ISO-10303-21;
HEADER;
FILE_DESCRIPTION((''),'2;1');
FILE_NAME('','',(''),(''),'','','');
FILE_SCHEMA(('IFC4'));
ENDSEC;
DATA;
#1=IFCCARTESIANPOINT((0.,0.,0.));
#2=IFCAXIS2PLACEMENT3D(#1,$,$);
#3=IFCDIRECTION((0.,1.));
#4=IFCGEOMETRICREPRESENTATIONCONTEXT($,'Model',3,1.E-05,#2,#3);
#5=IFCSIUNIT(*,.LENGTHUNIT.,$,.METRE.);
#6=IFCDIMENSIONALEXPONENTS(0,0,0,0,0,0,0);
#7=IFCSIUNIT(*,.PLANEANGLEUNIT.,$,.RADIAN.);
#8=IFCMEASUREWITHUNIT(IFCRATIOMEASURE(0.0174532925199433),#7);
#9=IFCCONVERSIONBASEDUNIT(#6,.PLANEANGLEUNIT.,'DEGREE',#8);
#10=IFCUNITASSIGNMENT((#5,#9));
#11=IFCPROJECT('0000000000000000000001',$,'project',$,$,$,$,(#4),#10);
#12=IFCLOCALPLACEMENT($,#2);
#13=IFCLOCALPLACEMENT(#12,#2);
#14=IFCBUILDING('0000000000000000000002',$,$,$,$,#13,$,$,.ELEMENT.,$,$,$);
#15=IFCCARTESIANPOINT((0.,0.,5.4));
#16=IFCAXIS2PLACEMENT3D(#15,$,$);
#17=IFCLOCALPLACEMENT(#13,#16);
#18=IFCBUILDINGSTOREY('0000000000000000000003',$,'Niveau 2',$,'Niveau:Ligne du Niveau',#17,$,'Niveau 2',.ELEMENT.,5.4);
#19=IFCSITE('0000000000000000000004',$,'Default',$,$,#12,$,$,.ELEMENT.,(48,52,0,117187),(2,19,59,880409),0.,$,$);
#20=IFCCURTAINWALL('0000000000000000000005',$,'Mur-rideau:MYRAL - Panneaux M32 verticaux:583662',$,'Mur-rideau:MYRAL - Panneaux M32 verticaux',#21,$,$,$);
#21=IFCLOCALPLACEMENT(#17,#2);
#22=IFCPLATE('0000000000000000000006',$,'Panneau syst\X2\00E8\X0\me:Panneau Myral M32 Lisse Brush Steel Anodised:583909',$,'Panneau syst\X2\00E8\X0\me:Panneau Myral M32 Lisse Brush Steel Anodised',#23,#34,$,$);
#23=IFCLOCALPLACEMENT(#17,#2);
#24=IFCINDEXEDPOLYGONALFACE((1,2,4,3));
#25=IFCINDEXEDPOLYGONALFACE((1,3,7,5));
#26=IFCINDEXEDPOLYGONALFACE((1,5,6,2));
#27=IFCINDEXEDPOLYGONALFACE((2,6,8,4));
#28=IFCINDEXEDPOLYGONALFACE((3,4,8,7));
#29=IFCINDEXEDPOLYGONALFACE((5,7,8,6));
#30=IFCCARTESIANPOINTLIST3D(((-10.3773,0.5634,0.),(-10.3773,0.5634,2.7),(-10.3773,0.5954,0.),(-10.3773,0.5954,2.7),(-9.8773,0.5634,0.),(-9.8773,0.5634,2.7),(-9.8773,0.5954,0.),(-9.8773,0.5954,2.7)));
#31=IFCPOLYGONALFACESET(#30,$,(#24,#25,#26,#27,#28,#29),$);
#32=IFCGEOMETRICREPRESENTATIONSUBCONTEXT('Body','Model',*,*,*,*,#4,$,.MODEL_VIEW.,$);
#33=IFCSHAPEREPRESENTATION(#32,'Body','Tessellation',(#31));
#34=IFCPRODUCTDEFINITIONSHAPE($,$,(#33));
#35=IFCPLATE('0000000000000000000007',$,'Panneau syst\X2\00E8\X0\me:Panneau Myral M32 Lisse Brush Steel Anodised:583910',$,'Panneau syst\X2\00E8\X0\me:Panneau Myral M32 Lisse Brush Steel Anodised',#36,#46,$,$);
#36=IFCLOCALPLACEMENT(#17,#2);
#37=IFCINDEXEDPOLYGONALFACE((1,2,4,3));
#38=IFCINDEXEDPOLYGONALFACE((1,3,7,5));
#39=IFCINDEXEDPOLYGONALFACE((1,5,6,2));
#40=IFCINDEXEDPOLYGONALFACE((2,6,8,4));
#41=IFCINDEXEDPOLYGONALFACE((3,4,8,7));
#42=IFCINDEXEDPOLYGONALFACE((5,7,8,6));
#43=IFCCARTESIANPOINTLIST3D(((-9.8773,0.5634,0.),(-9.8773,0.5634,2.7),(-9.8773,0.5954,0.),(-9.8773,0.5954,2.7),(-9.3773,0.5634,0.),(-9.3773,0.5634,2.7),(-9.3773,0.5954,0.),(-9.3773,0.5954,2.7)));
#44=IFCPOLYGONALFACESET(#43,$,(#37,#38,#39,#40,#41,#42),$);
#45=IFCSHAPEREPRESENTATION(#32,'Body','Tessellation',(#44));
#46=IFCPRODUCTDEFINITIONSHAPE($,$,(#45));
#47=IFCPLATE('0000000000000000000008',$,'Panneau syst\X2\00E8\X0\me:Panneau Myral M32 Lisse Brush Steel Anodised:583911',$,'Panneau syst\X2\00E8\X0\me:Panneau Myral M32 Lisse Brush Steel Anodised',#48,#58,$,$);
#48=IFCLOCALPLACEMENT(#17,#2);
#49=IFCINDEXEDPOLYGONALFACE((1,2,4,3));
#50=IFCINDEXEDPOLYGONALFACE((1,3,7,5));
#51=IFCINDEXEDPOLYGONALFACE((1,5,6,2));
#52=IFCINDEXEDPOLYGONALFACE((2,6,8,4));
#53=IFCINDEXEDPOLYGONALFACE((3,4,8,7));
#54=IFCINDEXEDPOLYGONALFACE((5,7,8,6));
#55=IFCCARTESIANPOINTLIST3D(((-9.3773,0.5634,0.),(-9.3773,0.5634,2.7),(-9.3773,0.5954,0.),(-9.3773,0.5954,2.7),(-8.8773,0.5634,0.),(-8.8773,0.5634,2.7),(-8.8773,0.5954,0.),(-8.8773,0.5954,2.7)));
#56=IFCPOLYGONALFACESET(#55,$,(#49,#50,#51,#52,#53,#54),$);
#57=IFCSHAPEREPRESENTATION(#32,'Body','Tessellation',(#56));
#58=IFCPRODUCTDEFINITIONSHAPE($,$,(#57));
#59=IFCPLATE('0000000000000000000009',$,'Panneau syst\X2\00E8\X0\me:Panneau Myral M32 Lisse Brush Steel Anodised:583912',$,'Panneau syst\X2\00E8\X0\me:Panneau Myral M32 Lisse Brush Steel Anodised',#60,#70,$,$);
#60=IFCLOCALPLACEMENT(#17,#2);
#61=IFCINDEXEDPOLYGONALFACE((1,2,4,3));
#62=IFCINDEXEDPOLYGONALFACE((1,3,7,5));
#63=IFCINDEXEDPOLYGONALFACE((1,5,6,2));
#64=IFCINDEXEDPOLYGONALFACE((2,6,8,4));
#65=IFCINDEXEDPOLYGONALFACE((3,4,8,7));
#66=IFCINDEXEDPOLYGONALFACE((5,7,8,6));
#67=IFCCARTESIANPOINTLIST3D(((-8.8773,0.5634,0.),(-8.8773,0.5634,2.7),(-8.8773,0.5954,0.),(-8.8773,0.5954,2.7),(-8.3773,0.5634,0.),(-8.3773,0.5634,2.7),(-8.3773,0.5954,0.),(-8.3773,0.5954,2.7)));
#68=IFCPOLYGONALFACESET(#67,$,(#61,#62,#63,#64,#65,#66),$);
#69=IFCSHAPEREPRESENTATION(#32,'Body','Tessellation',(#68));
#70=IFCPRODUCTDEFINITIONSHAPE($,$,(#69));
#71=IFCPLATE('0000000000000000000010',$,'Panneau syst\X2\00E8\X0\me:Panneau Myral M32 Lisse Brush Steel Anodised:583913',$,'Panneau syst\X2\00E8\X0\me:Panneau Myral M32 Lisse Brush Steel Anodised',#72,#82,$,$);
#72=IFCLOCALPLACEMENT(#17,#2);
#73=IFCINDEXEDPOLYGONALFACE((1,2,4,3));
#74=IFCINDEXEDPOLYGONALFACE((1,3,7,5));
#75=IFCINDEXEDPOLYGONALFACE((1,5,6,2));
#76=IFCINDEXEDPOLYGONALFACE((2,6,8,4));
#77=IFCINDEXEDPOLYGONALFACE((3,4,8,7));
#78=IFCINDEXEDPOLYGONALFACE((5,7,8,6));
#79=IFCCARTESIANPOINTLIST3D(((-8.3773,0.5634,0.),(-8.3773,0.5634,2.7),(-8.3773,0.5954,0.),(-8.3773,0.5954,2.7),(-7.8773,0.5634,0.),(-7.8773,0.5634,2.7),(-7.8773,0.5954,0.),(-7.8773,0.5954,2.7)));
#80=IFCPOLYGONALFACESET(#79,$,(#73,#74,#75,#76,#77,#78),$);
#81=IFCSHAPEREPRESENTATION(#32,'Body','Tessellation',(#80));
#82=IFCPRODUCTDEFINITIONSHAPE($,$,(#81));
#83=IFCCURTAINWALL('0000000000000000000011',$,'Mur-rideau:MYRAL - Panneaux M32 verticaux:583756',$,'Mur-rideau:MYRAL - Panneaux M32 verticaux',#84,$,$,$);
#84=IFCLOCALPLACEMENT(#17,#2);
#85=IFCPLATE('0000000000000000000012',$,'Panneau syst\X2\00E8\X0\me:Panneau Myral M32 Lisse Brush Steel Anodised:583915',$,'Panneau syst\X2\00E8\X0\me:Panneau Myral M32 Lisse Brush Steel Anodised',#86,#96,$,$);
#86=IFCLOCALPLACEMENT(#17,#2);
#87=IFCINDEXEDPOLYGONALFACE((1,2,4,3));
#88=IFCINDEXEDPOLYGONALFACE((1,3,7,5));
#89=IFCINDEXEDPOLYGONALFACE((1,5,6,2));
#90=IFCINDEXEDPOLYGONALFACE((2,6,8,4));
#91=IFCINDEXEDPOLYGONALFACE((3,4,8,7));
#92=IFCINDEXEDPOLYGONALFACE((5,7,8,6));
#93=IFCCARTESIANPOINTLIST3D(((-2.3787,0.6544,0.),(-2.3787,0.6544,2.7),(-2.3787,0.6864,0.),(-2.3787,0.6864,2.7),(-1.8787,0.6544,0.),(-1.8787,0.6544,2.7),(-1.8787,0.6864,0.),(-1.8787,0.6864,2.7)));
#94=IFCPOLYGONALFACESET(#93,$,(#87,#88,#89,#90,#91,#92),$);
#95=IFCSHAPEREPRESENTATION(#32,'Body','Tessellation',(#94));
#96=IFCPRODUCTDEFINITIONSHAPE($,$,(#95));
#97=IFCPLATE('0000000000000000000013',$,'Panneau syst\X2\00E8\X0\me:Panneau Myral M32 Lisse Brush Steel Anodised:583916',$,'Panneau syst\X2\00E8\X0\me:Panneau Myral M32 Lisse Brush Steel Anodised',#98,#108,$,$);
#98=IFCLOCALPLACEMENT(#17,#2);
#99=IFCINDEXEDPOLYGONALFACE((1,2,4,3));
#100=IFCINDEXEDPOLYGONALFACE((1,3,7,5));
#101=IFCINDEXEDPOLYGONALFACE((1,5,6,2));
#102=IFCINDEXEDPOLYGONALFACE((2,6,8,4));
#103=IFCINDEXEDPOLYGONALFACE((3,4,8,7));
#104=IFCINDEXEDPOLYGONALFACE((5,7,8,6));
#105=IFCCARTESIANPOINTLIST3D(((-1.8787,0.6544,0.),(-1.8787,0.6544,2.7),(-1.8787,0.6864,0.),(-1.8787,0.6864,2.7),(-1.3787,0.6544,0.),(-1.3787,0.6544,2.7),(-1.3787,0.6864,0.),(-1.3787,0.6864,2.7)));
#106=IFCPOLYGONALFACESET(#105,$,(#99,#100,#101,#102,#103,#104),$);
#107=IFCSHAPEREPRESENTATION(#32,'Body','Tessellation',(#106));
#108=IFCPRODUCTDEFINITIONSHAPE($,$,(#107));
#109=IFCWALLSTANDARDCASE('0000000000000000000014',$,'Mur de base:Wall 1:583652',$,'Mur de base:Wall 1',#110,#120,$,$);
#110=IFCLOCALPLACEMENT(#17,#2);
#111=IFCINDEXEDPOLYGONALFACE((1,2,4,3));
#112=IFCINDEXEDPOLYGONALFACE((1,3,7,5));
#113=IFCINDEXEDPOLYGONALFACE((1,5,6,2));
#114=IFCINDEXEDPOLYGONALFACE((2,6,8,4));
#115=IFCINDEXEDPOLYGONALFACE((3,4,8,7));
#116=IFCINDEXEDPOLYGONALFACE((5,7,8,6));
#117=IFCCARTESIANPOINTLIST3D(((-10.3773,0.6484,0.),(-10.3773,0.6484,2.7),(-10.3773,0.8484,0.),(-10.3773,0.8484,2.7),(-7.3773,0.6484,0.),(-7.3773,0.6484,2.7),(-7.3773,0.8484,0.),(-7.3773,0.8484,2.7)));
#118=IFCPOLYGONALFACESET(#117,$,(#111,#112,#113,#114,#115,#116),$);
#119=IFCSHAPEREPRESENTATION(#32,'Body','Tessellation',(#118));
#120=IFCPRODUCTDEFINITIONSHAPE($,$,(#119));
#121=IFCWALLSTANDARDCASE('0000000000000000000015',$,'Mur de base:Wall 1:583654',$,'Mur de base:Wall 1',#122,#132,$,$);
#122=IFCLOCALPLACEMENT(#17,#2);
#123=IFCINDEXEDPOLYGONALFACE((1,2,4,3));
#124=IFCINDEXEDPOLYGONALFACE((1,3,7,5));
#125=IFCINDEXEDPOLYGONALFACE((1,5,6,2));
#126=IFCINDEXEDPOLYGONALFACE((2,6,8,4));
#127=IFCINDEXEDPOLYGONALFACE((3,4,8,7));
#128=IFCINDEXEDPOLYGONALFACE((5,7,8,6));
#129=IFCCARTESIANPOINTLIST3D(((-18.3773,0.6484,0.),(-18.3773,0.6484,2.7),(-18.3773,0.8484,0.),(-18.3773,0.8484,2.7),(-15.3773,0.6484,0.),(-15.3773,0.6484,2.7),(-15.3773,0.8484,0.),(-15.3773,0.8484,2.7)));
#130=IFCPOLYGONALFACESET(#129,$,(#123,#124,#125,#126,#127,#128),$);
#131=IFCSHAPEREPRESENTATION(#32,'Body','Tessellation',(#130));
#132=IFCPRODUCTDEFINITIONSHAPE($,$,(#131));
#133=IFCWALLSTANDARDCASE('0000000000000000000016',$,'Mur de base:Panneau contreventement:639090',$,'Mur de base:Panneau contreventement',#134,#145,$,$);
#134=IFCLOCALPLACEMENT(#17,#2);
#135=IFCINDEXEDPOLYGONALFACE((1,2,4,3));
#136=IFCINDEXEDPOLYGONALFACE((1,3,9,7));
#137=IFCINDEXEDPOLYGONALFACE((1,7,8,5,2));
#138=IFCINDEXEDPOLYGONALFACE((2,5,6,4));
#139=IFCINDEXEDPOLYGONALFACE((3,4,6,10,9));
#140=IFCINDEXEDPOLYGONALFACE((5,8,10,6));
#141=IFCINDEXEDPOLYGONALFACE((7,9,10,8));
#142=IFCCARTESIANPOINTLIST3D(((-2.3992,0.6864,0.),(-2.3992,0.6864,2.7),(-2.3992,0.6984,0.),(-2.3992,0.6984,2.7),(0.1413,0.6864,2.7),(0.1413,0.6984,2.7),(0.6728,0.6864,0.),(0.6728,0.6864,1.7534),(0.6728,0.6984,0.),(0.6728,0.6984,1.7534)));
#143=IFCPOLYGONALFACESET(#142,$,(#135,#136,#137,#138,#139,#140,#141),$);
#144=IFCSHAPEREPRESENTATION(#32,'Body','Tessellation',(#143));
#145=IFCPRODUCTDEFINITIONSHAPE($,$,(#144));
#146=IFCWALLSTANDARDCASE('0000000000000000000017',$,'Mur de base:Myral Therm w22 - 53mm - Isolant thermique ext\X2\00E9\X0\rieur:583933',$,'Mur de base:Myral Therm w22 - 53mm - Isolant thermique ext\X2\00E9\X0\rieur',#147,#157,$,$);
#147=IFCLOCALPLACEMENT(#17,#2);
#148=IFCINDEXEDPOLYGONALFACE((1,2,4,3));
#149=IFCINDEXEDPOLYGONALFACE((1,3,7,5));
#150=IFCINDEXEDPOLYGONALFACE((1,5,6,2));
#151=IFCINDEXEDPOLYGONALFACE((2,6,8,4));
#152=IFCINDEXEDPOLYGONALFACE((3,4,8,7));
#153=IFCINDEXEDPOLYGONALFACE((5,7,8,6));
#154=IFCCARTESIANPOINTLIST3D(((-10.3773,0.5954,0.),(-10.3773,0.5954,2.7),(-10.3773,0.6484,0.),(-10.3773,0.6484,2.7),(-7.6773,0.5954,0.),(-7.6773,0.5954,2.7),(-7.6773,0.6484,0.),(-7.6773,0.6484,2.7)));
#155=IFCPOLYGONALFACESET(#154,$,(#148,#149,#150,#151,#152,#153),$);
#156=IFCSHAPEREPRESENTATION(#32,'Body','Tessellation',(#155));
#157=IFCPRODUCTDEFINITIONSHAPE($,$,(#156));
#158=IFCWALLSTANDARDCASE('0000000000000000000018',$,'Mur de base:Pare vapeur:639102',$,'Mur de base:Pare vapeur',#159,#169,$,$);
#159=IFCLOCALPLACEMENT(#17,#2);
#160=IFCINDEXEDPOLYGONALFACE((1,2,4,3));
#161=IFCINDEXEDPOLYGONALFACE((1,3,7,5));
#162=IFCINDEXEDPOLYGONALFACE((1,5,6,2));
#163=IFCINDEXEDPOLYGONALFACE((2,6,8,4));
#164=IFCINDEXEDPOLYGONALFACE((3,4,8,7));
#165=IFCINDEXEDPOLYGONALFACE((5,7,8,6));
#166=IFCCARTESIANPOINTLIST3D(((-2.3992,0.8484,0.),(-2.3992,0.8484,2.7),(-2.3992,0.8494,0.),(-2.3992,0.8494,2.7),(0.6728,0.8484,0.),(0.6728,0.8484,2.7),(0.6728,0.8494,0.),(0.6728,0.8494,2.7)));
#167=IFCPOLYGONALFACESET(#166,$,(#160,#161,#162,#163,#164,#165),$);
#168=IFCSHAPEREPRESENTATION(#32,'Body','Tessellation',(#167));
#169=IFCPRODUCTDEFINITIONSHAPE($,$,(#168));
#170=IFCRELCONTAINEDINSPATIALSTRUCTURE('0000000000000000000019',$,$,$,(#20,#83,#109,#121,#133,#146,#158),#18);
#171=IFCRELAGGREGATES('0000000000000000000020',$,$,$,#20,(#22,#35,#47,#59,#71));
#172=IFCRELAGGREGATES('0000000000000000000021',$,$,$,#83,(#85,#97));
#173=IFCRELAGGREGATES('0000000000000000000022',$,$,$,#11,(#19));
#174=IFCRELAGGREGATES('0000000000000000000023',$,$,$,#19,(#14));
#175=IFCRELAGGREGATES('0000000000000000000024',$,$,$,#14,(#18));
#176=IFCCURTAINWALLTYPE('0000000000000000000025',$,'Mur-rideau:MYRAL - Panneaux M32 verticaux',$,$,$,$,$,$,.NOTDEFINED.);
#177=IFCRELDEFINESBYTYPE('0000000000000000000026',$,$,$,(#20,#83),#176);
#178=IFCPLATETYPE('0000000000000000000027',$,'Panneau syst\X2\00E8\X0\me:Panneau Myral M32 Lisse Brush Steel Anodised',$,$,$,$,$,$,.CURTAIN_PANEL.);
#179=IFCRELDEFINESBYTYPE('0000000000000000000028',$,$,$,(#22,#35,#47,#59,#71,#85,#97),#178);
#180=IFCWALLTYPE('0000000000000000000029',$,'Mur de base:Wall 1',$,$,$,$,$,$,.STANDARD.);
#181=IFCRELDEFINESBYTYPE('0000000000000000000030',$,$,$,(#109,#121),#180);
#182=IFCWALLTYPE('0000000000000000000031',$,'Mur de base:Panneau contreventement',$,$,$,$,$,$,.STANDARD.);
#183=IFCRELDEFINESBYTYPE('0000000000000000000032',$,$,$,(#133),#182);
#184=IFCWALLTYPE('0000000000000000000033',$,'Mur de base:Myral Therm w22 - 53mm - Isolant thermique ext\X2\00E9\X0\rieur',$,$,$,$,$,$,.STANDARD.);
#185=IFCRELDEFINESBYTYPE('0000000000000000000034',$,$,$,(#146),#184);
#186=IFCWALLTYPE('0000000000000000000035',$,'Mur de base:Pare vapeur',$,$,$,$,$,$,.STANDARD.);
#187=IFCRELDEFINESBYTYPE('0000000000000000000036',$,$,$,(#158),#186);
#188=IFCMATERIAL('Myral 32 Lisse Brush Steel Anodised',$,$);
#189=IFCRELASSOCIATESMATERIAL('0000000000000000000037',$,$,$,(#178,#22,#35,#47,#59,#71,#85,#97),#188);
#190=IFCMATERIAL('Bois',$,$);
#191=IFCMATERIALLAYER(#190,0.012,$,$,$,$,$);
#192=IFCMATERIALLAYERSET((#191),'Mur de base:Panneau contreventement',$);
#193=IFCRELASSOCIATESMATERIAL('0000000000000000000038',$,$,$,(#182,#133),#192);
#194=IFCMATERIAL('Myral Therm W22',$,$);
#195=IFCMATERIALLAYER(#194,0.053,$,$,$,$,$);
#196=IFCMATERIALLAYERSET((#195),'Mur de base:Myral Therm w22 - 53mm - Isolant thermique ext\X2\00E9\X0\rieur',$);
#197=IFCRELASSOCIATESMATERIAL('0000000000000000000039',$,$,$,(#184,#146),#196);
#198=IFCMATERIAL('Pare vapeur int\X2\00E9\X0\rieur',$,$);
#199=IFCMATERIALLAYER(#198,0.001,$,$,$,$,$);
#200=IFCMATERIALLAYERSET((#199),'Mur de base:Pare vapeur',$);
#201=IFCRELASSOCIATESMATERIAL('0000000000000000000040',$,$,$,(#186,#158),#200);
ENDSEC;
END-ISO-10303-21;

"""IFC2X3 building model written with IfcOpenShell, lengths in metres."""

from ifc_helpers import new_model, entity, si_unit, converted_unit, direction, frame, frame_2d, origin, origin_2d_with_axis, place, context, subcontext, project, spatial, rectangle, extrude, clip, halfspace, source, transform, mapped, material, layer, layer_set, layer_usage, type_object, type_shapes, element, aggregate, save


model = new_model("IFC2X3")

# Units and contexts
model_context = context("Model", 3, precision=1e-05, world=origin(), true_north=direction((0.0, 1.0)))
body_context = subcontext(model_context, "Body", "Model", "MODEL_VIEW")
ifc_project = project(units=[si_unit("LENGTHUNIT", "METRE"), converted_unit("PLANEANGLEUNIT", "DEGREE", entity("IfcRatioMeasure", 0.0174532925199433), si_unit("PLANEANGLEUNIT", "RADIAN"), dimensions=[0, 0, 0, 0, 0, 0, 0])], contexts=[model_context])

# Site, building, storey
site_placement = place(None, origin())
site = spatial("IfcSite", under=ifc_project, at=site_placement, Name="Default", CompositionType="ELEMENT", RefLatitude=(48, 52, 0, 117187), RefLongitude=(2, 19, 59, 880409), RefElevation=0.0)
building_placement = place(site_placement, origin())
building = spatial("IfcBuilding", under=site, at=building_placement, CompositionType="ELEMENT")
storey_placement = place(building_placement, frame((0.0, 0.0, 5.4)))
storey = spatial("IfcBuildingStorey", under=building, at=storey_placement, Name="Niveau 2", ObjectType="Niveau:Ligne du Niveau", LongName="Niveau 2", CompositionType="ELEMENT", Elevation=5.4)

# Shared definitions
ifc_material_1 = material(Name="Bois")

# Curtain walls, plates
curtain_wall_type_1 = type_object("IfcCurtainWallType", Name="Mur-rideau:MYRAL - Panneaux M32 verticaux", PredefinedType="NOTDEFINED")
ifc_material_2 = material(Name="Myral 32 Lisse Brush Steel Anodised")
plate_type = type_object("IfcPlateType", Name="Panneau système:Panneau Myral M32 Lisse Brush Steel Anodised", PredefinedType="CURTAIN_PANEL", material=ifc_material_2)
shared_shape_1 = source(origin(), body_context, "Body", "SweptSolid", [
    extrude(rectangle(XDim=0.032, YDim=0.5, at=origin_2d_with_axis()), frame((0.0, -0.016, 0.0), z_axis=(0.0, 0.0, 1.0), x_axis=(0.0, 1.0, 0.0)), (0.0, 0.0, 1.0), 2.7),
])
type_shapes(plate_type, [shared_shape_1])
curtain_wall_1_placement = place(storey_placement, frame((0.0, 0.0, -5.4)))
curtain_wall_1 = element("IfcCurtainWall", 1, at=curtain_wall_1_placement, inside=storey, type_object=curtain_wall_type_1, Name="Mur-rideau:MYRAL - Panneaux M32 verticaux:583662", ObjectType="Mur-rideau:MYRAL - Panneaux M32 verticaux")
plate_1_placement = place(curtain_wall_1_placement, frame((-10.1273, 0.5954, 5.4)))
plate_1 = element("IfcPlate", 2, at=plate_1_placement, type_object=plate_type, material=ifc_material_2, Name="Panneau système:Panneau Myral M32 Lisse Brush Steel Anodised:583909", ObjectType="Panneau système:Panneau Myral M32 Lisse Brush Steel Anodised", context=body_context, shape_type="MappedRepresentation", body=[
    mapped(shared_shape_1, transform((0.0, 0.0, 0.0), scale=1.0)),
])
plate_2_placement = place(curtain_wall_1_placement, frame((-9.6273, 0.5954, 5.4)))
plate_2 = element("IfcPlate", 3, at=plate_2_placement, type_object=plate_type, material=ifc_material_2, Name="Panneau système:Panneau Myral M32 Lisse Brush Steel Anodised:583910", ObjectType="Panneau système:Panneau Myral M32 Lisse Brush Steel Anodised", context=body_context, shape_type="MappedRepresentation", body=[
    mapped(shared_shape_1, transform((0.0, 0.0, 0.0), scale=1.0)),
])
plate_3_placement = place(curtain_wall_1_placement, frame((-9.1273, 0.5954, 5.4)))
plate_3 = element("IfcPlate", 4, at=plate_3_placement, type_object=plate_type, material=ifc_material_2, Name="Panneau système:Panneau Myral M32 Lisse Brush Steel Anodised:583911", ObjectType="Panneau système:Panneau Myral M32 Lisse Brush Steel Anodised", context=body_context, shape_type="MappedRepresentation", body=[
    mapped(shared_shape_1, transform((0.0, 0.0, 0.0), scale=1.0)),
])
plate_4_placement = place(curtain_wall_1_placement, frame((-8.6273, 0.5954, 5.4)))
plate_4 = element("IfcPlate", 5, at=plate_4_placement, type_object=plate_type, material=ifc_material_2, Name="Panneau système:Panneau Myral M32 Lisse Brush Steel Anodised:583912", ObjectType="Panneau système:Panneau Myral M32 Lisse Brush Steel Anodised", context=body_context, shape_type="MappedRepresentation", body=[
    mapped(shared_shape_1, transform((0.0, 0.0, 0.0), scale=1.0)),
])
plate_5_placement = place(curtain_wall_1_placement, frame((-8.1273, 0.5954, 5.4)))
plate_5 = element("IfcPlate", 6, at=plate_5_placement, type_object=plate_type, material=ifc_material_2, Name="Panneau système:Panneau Myral M32 Lisse Brush Steel Anodised:583913", ObjectType="Panneau système:Panneau Myral M32 Lisse Brush Steel Anodised", context=body_context, shape_type="MappedRepresentation", body=[
    mapped(shared_shape_1, transform((0.0, 0.0, 0.0), scale=1.0)),
])
aggregate(curtain_wall_1, [plate_1, plate_2, plate_3, plate_4, plate_5])
curtain_wall_2_placement = place(storey_placement, frame((0.0, 0.0, -5.4)))
curtain_wall_2 = element("IfcCurtainWall", 7, at=curtain_wall_2_placement, inside=storey, type_object=curtain_wall_type_1, Name="Mur-rideau:MYRAL - Panneaux M32 verticaux:583756", ObjectType="Mur-rideau:MYRAL - Panneaux M32 verticaux")
plate_6_placement = place(curtain_wall_2_placement, frame((-2.1287, 0.6864, 5.4)))
plate_6 = element("IfcPlate", 8, at=plate_6_placement, type_object=plate_type, material=ifc_material_2, Name="Panneau système:Panneau Myral M32 Lisse Brush Steel Anodised:583915", ObjectType="Panneau système:Panneau Myral M32 Lisse Brush Steel Anodised", context=body_context, shape_type="MappedRepresentation", body=[
    mapped(shared_shape_1, transform((0.0, 0.0, 0.0), scale=1.0)),
])
plate_7_placement = place(curtain_wall_2_placement, frame((-1.6287, 0.6864, 5.4)))
plate_7 = element("IfcPlate", 9, at=plate_7_placement, type_object=plate_type, material=ifc_material_2, Name="Panneau système:Panneau Myral M32 Lisse Brush Steel Anodised:583916", ObjectType="Panneau système:Panneau Myral M32 Lisse Brush Steel Anodised", context=body_context, shape_type="MappedRepresentation", body=[
    mapped(shared_shape_1, transform((0.0, 0.0, 0.0), scale=1.0)),
])
aggregate(curtain_wall_2, [plate_6, plate_7])

# Walls
wall_type_1 = type_object("IfcWallType", Name="Mur de base:Wall 1", PredefinedType="STANDARD")
for number, where, name in (
    (10, (-10.3773, 0.7484, 0.0), "Mur de base:Wall 1:583652"),
    (11, (-18.3773, 0.7484, 0.0), "Mur de base:Wall 1:583654"),
):
    element("IfcWallStandardCase", number, at=place(storey_placement, frame(where)), inside=storey, type_object=wall_type_1, Name=name, ObjectType="Mur de base:Wall 1", context=body_context, shape_type="SweptSolid", body=[
        extrude(rectangle(XDim=3.0, YDim=0.2, at=frame_2d((1.5, 0.0), x_axis=(-1.0, 0.0))), origin(), (0.0, 0.0, 1.0), 2.7),
    ])
ifc_layer_1 = layer(ifc_material_1, 0.012)
ifc_layer_set_1 = layer_set([ifc_layer_1], Name="Mur de base:Panneau contreventement")
ifc_layer_usage_1 = layer_usage(ifc_layer_set_1, "AXIS2", "NEGATIVE", 0.006)
wall_type_2 = type_object("IfcWallType", Name="Mur de base:Panneau contreventement", PredefinedType="STANDARD", material=ifc_layer_set_1)
wall_1_placement = place(storey_placement, frame((-2.3992, 0.6924, 0.0)))
element("IfcWallStandardCase", 12, at=wall_1_placement, inside=storey, type_object=wall_type_2, material=ifc_layer_usage_1, Name="Mur de base:Panneau contreventement:639090", ObjectType="Mur de base:Panneau contreventement", context=body_context, shape_type="Clipping", body=[
    clip(extrude(rectangle(XDim=3.072, YDim=0.012, at=frame_2d((1.536, 0.0), x_axis=(-1.0, 0.0))), origin(), (0.0, 0.0, 1.0), 2.7), halfspace(frame((2.5405, -0.006, 2.7), z_axis=(0.871952, 0.0, 0.489592), x_axis=(0.0, 1.0, 0.0)), False)),
])
ifc_material_3 = material(Name="Myral Therm W22")
ifc_layer_2 = layer(ifc_material_3, 0.053)
ifc_layer_set_2 = layer_set([ifc_layer_2], Name="Mur de base:Myral Therm w22 - 53mm - Isolant thermique extérieur")
ifc_layer_usage_2 = layer_usage(ifc_layer_set_2, "AXIS2", "NEGATIVE", 0.0265)
wall_type_3 = type_object("IfcWallType", Name="Mur de base:Myral Therm w22 - 53mm - Isolant thermique extérieur", PredefinedType="STANDARD", material=ifc_layer_set_2)
wall_2_placement = place(storey_placement, frame((-10.3773, 0.6219, 0.0)))
element("IfcWallStandardCase", 13, at=wall_2_placement, inside=storey, type_object=wall_type_3, material=ifc_layer_usage_2, Name="Mur de base:Myral Therm w22 - 53mm - Isolant thermique extérieur:583933", ObjectType="Mur de base:Myral Therm w22 - 53mm - Isolant thermique extérieur", context=body_context, shape_type="SweptSolid", body=[
    extrude(rectangle(XDim=2.7, YDim=0.053, at=frame_2d((1.35, 0.0), x_axis=(-1.0, 0.0))), origin(), (0.0, 0.0, 1.0), 2.7),
])
ifc_material_4 = material(Name="Pare vapeur intérieur")
ifc_layer_3 = layer(ifc_material_4, 0.001)
ifc_layer_set_3 = layer_set([ifc_layer_3], Name="Mur de base:Pare vapeur")
ifc_layer_usage_3 = layer_usage(ifc_layer_set_3, "AXIS2", "NEGATIVE", 0.0005)
wall_type_4 = type_object("IfcWallType", Name="Mur de base:Pare vapeur", PredefinedType="STANDARD", material=ifc_layer_set_3)
wall_3_placement = place(storey_placement, frame((-2.3992, 0.8489, 0.0)))
element("IfcWallStandardCase", 14, at=wall_3_placement, inside=storey, type_object=wall_type_4, material=ifc_layer_usage_3, Name="Mur de base:Pare vapeur:639102", ObjectType="Mur de base:Pare vapeur", context=body_context, shape_type="SweptSolid", body=[
    extrude(rectangle(XDim=3.072, YDim=0.001, at=frame_2d((1.536, 0.0), x_axis=(-1.0, 0.0))), origin(), (0.0, 0.0, 1.0), 2.7),
])

save(model, "model.ifc")
